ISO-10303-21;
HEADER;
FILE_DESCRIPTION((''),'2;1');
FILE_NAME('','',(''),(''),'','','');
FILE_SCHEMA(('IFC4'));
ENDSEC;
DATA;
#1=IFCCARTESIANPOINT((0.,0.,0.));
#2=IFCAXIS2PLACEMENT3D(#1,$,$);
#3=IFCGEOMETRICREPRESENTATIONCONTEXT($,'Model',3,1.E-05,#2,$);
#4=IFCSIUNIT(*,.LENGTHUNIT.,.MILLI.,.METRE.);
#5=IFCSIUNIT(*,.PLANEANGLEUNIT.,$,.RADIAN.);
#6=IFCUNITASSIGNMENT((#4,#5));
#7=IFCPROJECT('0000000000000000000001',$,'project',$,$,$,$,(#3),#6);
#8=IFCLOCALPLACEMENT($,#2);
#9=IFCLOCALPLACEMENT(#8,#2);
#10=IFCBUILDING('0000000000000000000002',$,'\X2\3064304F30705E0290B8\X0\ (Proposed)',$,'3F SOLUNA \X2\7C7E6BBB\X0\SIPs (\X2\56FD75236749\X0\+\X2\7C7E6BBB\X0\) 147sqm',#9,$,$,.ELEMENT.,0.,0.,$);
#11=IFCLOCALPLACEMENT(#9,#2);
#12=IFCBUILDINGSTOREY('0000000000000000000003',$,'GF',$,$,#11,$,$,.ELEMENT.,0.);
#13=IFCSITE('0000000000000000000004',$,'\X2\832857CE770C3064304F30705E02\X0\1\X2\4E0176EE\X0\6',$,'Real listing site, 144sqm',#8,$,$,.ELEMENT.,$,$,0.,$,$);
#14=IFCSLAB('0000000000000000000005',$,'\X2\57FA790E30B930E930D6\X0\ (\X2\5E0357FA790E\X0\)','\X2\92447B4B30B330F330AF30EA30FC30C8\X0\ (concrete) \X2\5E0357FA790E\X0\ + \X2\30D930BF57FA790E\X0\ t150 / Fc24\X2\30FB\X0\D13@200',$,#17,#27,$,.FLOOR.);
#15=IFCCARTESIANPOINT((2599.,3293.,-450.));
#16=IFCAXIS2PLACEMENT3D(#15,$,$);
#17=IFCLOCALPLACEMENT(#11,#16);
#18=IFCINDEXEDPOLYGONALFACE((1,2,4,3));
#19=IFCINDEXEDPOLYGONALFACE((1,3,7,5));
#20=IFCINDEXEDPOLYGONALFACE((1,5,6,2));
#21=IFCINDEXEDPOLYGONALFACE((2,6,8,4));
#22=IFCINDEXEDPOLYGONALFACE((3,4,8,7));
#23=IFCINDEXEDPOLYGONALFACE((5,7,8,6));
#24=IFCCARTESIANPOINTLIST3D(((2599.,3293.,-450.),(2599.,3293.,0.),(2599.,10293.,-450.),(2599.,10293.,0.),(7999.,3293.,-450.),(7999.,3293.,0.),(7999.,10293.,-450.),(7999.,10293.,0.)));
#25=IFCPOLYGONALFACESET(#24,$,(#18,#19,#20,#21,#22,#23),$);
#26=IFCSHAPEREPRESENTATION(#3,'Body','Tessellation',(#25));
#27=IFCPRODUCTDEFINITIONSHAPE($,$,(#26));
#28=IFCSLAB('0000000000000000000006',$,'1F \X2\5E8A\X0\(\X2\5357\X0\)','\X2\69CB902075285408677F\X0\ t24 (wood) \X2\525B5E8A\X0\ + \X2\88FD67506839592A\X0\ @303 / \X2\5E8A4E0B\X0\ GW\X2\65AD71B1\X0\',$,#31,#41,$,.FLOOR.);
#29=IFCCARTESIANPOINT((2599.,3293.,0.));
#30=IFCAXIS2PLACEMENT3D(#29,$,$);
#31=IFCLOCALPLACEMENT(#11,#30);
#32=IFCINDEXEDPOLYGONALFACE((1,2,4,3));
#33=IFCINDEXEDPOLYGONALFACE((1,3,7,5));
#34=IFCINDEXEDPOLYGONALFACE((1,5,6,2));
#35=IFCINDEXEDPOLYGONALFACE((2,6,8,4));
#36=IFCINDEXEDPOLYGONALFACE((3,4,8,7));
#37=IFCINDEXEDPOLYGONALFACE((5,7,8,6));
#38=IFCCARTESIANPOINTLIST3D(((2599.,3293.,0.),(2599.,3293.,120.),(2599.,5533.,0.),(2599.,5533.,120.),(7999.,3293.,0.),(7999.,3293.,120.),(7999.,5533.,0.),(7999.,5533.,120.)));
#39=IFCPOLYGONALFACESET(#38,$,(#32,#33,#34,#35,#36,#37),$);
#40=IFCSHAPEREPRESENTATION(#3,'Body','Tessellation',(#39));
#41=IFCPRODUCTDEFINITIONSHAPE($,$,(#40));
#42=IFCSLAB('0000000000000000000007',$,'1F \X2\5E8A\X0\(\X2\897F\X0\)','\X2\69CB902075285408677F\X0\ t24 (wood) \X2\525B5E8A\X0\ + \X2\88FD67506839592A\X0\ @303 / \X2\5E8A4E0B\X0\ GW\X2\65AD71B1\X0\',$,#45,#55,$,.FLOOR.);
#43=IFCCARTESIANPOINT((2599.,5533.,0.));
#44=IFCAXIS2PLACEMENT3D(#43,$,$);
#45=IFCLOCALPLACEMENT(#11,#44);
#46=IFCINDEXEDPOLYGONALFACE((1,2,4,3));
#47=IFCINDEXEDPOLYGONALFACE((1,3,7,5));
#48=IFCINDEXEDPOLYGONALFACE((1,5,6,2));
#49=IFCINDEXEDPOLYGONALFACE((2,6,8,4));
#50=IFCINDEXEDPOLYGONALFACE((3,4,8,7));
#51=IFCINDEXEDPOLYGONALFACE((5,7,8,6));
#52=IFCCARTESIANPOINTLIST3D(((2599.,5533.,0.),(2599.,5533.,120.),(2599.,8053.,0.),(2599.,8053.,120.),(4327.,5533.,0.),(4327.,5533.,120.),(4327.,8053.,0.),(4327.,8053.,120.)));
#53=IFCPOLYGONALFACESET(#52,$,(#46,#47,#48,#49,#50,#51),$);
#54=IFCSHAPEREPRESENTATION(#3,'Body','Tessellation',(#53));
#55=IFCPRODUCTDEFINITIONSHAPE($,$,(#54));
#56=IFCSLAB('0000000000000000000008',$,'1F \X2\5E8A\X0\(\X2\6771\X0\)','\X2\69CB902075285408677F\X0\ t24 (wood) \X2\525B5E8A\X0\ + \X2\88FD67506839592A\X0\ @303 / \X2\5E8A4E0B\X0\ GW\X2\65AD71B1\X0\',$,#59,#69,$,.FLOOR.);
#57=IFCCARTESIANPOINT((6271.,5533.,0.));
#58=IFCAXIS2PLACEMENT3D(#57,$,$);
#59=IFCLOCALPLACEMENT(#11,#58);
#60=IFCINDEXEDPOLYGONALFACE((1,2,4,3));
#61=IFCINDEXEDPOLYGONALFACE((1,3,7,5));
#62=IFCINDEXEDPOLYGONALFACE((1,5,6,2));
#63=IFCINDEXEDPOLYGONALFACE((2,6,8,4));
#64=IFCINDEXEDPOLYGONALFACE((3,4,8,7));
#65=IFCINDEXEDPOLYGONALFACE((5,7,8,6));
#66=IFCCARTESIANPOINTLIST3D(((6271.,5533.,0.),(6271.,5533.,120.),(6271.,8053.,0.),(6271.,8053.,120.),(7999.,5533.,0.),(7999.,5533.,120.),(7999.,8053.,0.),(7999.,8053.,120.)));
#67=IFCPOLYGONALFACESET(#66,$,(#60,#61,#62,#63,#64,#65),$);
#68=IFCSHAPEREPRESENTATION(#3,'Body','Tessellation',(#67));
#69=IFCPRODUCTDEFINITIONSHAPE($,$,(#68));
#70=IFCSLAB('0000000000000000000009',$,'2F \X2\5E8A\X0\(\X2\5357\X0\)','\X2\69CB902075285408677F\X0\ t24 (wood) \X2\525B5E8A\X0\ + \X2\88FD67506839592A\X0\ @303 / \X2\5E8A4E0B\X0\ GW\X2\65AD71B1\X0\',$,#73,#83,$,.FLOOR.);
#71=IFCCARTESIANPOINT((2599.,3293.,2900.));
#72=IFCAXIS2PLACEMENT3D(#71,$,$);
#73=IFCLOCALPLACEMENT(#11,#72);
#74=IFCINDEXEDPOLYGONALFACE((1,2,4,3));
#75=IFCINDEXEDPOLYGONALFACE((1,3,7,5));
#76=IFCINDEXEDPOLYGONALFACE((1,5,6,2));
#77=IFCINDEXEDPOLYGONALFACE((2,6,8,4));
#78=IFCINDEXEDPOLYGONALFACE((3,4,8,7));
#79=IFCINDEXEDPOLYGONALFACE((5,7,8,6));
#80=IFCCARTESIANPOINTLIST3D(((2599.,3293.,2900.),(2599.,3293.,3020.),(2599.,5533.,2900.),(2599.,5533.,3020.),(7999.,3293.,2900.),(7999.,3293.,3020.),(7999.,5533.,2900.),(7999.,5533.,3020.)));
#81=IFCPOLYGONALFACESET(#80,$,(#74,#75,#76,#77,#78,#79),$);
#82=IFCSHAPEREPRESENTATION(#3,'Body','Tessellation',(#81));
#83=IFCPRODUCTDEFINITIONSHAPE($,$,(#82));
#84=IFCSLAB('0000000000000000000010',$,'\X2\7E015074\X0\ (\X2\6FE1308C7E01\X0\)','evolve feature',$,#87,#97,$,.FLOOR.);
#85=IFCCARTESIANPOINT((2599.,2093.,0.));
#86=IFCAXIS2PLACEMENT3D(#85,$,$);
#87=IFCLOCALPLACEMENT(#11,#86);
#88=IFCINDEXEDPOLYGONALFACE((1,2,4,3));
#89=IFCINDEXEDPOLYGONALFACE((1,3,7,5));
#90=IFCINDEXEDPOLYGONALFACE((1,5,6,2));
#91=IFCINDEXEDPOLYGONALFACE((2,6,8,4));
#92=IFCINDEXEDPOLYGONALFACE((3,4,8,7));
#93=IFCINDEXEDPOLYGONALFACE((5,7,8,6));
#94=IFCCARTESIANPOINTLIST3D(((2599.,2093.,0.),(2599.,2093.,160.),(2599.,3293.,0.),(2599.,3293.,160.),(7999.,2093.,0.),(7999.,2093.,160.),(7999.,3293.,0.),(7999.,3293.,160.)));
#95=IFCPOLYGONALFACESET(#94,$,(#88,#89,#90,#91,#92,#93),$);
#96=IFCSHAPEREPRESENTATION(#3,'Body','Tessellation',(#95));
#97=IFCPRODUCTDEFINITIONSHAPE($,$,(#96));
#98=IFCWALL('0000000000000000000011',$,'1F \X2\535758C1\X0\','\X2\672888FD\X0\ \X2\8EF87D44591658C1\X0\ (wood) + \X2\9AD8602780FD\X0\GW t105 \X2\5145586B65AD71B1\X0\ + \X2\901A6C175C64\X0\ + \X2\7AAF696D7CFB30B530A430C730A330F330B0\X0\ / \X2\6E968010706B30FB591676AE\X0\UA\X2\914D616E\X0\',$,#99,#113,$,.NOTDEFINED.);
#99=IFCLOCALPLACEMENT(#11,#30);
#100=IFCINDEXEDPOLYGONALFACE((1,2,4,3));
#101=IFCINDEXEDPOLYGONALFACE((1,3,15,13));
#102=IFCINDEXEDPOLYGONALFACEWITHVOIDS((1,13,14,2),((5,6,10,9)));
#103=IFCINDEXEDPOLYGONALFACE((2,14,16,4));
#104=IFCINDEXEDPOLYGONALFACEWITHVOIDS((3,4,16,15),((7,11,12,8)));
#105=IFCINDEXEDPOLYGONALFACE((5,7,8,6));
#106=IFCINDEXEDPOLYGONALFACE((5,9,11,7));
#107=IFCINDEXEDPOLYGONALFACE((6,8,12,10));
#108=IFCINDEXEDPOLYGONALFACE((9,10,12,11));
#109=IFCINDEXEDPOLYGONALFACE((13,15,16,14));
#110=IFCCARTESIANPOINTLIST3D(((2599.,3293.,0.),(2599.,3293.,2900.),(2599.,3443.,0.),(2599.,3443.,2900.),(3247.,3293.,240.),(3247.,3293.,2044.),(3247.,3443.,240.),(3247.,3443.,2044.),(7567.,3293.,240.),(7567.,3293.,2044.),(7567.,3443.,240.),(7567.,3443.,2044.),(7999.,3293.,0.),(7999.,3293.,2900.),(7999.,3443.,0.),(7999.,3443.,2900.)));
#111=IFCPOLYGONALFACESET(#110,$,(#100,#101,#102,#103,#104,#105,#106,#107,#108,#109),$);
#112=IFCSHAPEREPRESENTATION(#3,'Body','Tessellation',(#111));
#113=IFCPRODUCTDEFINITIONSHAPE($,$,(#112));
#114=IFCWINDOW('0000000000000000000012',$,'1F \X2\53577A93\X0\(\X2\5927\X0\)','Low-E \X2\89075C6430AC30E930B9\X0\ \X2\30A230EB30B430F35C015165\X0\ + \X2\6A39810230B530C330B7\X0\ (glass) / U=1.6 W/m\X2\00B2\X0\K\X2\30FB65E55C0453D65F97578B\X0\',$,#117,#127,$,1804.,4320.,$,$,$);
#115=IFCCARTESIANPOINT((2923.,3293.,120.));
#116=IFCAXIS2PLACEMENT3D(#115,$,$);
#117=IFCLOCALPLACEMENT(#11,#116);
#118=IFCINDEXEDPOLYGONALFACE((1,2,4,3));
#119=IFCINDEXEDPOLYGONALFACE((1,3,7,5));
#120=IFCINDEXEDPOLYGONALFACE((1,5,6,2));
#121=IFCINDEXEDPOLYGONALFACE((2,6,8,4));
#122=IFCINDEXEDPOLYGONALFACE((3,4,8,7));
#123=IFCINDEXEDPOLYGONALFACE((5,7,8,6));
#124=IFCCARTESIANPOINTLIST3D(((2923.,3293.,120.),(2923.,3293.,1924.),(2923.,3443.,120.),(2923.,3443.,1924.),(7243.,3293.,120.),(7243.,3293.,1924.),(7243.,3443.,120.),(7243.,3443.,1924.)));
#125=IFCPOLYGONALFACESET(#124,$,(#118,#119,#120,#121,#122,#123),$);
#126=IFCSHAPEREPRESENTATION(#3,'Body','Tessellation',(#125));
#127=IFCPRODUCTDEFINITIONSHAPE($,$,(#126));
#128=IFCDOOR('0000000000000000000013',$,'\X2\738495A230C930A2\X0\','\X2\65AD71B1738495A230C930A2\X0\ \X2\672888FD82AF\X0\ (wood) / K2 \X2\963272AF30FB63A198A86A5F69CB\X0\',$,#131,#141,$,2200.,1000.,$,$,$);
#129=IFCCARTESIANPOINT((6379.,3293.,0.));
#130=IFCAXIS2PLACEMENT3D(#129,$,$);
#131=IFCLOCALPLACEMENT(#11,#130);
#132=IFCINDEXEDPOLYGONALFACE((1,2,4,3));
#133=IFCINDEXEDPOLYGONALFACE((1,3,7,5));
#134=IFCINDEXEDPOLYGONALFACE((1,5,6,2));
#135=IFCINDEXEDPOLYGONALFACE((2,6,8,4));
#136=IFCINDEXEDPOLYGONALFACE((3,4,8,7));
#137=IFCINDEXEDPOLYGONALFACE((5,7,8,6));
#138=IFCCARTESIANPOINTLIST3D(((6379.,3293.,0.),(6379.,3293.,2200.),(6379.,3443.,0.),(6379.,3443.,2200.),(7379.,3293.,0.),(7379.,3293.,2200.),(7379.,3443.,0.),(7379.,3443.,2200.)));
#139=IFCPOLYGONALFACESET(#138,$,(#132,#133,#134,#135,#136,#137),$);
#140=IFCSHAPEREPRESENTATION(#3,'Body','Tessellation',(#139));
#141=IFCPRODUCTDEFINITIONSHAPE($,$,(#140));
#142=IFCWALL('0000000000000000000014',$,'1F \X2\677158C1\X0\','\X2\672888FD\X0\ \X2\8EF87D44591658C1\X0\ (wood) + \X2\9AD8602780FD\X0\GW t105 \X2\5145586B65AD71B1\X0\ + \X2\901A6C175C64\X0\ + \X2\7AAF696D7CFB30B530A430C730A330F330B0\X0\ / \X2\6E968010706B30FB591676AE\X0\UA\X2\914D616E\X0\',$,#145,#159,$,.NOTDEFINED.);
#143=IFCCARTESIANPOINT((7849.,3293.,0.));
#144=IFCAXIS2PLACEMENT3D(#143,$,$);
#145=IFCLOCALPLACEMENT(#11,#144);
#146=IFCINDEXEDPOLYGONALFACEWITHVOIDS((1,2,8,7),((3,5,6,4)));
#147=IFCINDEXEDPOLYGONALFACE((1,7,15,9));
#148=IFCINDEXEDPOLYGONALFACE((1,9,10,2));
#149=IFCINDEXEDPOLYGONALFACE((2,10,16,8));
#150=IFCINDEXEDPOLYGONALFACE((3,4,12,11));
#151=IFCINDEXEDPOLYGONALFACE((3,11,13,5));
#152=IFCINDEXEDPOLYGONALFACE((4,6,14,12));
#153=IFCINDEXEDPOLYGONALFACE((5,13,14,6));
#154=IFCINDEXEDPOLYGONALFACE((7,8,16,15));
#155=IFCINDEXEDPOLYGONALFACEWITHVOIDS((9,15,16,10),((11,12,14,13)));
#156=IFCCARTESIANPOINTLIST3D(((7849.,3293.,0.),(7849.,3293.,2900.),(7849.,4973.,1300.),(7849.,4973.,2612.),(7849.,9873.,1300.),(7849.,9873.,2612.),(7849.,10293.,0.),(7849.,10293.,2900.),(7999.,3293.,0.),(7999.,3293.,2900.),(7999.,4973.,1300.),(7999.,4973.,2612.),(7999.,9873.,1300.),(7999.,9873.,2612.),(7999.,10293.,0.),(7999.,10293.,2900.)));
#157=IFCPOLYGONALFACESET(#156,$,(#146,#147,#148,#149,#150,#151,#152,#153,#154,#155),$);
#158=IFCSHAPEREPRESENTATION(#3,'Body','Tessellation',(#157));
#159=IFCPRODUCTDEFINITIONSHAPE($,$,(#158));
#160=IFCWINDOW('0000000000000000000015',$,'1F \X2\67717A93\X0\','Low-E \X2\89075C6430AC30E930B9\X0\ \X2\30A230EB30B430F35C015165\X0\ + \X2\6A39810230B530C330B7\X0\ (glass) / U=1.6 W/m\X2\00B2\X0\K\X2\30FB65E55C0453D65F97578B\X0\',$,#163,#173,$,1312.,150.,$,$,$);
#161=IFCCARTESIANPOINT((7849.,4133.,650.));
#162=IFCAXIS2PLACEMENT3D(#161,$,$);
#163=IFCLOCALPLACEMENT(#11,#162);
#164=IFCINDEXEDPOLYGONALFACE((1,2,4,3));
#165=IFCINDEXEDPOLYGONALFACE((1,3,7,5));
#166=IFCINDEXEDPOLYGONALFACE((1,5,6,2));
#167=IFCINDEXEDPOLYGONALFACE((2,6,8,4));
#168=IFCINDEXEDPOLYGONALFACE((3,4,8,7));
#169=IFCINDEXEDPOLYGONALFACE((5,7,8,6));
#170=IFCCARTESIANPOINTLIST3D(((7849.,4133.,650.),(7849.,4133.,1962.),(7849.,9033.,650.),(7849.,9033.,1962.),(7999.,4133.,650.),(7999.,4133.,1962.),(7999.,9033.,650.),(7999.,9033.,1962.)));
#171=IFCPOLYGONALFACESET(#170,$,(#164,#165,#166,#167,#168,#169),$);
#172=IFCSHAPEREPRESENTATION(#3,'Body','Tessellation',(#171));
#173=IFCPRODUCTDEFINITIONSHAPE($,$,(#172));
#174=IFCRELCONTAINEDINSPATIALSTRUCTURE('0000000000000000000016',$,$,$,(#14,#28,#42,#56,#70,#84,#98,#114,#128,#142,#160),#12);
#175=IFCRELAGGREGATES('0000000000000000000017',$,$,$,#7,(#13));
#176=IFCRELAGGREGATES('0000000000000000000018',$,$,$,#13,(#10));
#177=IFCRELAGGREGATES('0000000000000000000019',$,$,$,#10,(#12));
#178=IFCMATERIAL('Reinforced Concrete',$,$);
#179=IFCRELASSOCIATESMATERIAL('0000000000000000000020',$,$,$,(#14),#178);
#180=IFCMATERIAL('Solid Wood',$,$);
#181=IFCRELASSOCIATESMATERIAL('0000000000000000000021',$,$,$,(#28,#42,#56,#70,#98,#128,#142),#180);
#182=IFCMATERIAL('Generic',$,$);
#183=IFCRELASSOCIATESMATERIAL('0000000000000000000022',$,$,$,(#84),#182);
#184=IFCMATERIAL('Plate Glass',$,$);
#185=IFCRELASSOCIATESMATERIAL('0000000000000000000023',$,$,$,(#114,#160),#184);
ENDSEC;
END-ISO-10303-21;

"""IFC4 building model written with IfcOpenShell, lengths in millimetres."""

from ifc_helpers import new_model, si_unit, frame, frame_2d, origin, place, context, project, spatial, rectangle, extrude, material, element, fill, save


model = new_model("IFC4")

# Units and contexts
model_context = context("Model", 3, precision=1e-05, world=origin())
ifc_project = project(units=[si_unit("LENGTHUNIT", "METRE", prefix="MILLI"), si_unit("PLANEANGLEUNIT", "RADIAN")], contexts=[model_context])

# Site, building, storey
site_placement = place(None, origin())
site = spatial("IfcSite", under=ifc_project, at=site_placement, Name="茨城県つくば市1丁目6", ObjectType="Real listing site, 144sqm", CompositionType="ELEMENT", RefElevation=0.0)
building_placement = place(site_placement, origin())
building = spatial("IfcBuilding", under=site, at=building_placement, Name="つくば市邸 (Proposed)", ObjectType="3F SOLUNA 籾殻SIPs (国産杉+籾殻) 147sqm", CompositionType="ELEMENT", ElevationOfRefHeight=0.0, ElevationOfTerrain=0.0)
storey_placement = place(building_placement, origin())
storey = spatial("IfcBuildingStorey", under=building, at=storey_placement, Name="GF", CompositionType="ELEMENT", Elevation=0.0)

# Slabs
ifc_material_1 = material(Name="Reinforced Concrete")
slab_1_placement = place(storey_placement, frame((2599.0, 3293.0, -450.0)))
element("IfcSlab", 1, at=slab_1_placement, inside=storey, material=ifc_material_1, Name="基礎スラブ (布基礎)", Description="鉄筋コンクリート (concrete) 布基礎 + ベタ基礎 t150 / Fc24・D13@200", PredefinedType="FLOOR", context=model_context, shape_type="SweptSolid", body=[
    extrude(rectangle(XDim=5400.0, YDim=7000.0, at=frame_2d((2700.0, 3500.0))), frame((2599.0, 3293.0, -450.0)), (0.0, 0.0, 1.0), 450.0),
])
ifc_material_2 = material(Name="Solid Wood")
slab_2_placement = place(storey_placement, frame((2599.0, 3293.0, 0.0)))
element("IfcSlab", 2, at=slab_2_placement, inside=storey, material=ifc_material_2, Name="1F 床(南)", Description="構造用合板 t24 (wood) 剛床 + 製材根太 @303 / 床下 GW断熱", PredefinedType="FLOOR", context=model_context, shape_type="SweptSolid", body=[
    extrude(rectangle(XDim=5400.0, YDim=2240.0, at=frame_2d((2700.0, 1120.0))), frame((2599.0, 3293.0, 0.0)), (0.0, 0.0, 1.0), 120.0),
])
slab_3_placement = place(storey_placement, frame((2599.0, 5533.0, 0.0)))
element("IfcSlab", 3, at=slab_3_placement, inside=storey, material=ifc_material_2, Name="1F 床(西)", Description="構造用合板 t24 (wood) 剛床 + 製材根太 @303 / 床下 GW断熱", PredefinedType="FLOOR", context=model_context, shape_type="SweptSolid", body=[
    extrude(rectangle(XDim=1728.0, YDim=2520.0, at=frame_2d((864.0, 1260.0))), frame((2599.0, 5533.0, 0.0)), (0.0, 0.0, 1.0), 120.0),
])
slab_4_placement = place(storey_placement, frame((6271.0, 5533.0, 0.0)))
element("IfcSlab", 4, at=slab_4_placement, inside=storey, material=ifc_material_2, Name="1F 床(東)", Description="構造用合板 t24 (wood) 剛床 + 製材根太 @303 / 床下 GW断熱", PredefinedType="FLOOR", context=model_context, shape_type="SweptSolid", body=[
    extrude(rectangle(XDim=1728.0, YDim=2520.0, at=frame_2d((864.0, 1260.0))), frame((6271.0, 5533.0, 0.0)), (0.0, 0.0, 1.0), 120.0),
])
slab_5_placement = place(storey_placement, frame((2599.0, 3293.0, 2900.0)))
element("IfcSlab", 5, at=slab_5_placement, inside=storey, material=ifc_material_2, Name="2F 床(南)", Description="構造用合板 t24 (wood) 剛床 + 製材根太 @303 / 床下 GW断熱", PredefinedType="FLOOR", context=model_context, shape_type="SweptSolid", body=[
    extrude(rectangle(XDim=5400.0, YDim=2240.0, at=frame_2d((2700.0, 1120.0))), frame((2599.0, 3293.0, 2900.0)), (0.0, 0.0, 1.0), 120.0),
])
ifc_material_3 = material(Name="Generic")
slab_6_placement = place(storey_placement, frame((2599.0, 2093.0, 0.0)))
element("IfcSlab", 6, at=slab_6_placement, inside=storey, material=ifc_material_3, Name="縁側 (濡れ縁)", Description="evolve feature", PredefinedType="FLOOR", context=model_context, shape_type="SweptSolid", body=[
    extrude(rectangle(XDim=5400.0, YDim=1200.0, at=frame_2d((2700.0, 600.0))), frame((2599.0, 2093.0, 0.0)), (0.0, 0.0, 1.0), 160.0),
])

# Wall, openings, window, door
wall_1_placement = place(storey_placement, frame((2599.0, 3293.0, 0.0)))
wall_1 = element("IfcWall", 7, at=wall_1_placement, inside=storey, material=ifc_material_2, Name="1F 南壁", Description="木製 軸組外壁 (wood) + 高性能GW t105 充填断熱 + 通気層 + 窯業系サイディング / 準耐火・外皮UA配慮", PredefinedType="NOTDEFINED", context=model_context, shape_type="SweptSolid", body=[
    extrude(rectangle(XDim=5400.0, YDim=150.0, at=frame_2d((2700.0, 75.0))), frame((2599.0, 3293.0, 0.0)), (0.0, 0.0, 1.0), 2900.0),
])
opening_1_placement = place(storey_placement, frame((2923.0, 3293.0, 120.0)))
opening_1 = element("IfcOpeningElement", 8, at=opening_1_placement, cuts=wall_1, PredefinedType="NOTDEFINED", context=model_context, shape_type="SweptSolid", body=[
    extrude(rectangle(XDim=4320.0, YDim=150.0, at=frame_2d((2160.0, 75.0))), frame((2923.0, 3293.0, 120.0)), (0.0, 0.0, 1.0), 1804.0),
])
opening_2_placement = place(storey_placement, frame((6379.0, 3293.0, 0.0)))
opening_2 = element("IfcOpeningElement", 9, at=opening_2_placement, cuts=wall_1, PredefinedType="NOTDEFINED", context=model_context, shape_type="SweptSolid", body=[
    extrude(rectangle(XDim=1000.0, YDim=150.0, at=frame_2d((500.0, 75.0))), frame((6379.0, 3293.0, 0.0)), (0.0, 0.0, 1.0), 2200.0),
])
ifc_material_4 = material(Name="Plate Glass")
window_1_placement = place(storey_placement, frame((2923.0, 3293.0, 120.0)))
window_1 = element("IfcWindow", 10, at=window_1_placement, inside=storey, material=ifc_material_4, Name="1F 南窓(大)", Description="Low-E 複層ガラス アルゴン封入 + 樹脂サッシ (glass) / U=1.6 W/m²K・日射取得型", OverallHeight=1804.0, OverallWidth=4320.0, context=model_context, shape_type="SweptSolid", body=[
    extrude(rectangle(XDim=4320.0, YDim=150.0, at=frame_2d((2160.0, 75.0))), frame((2923.0, 3293.0, 120.0)), (0.0, 0.0, 1.0), 1804.0),
])
fill(opening_1, window_1)
door_placement = place(storey_placement, frame((6379.0, 3293.0, 0.0)))
door = element("IfcDoor", 11, at=door_placement, inside=storey, material=ifc_material_2, Name="玄関ドア", Description="断熱玄関ドア 木製芯 (wood) / K2 防犯・採風機構", OverallHeight=2200.0, OverallWidth=1000.0, context=model_context, shape_type="SweptSolid", body=[
    extrude(rectangle(XDim=1000.0, YDim=150.0, at=frame_2d((500.0, 75.0))), frame((6379.0, 3293.0, 0.0)), (0.0, 0.0, 1.0), 2200.0),
])
fill(opening_2, door)

# Wall, opening, window
wall_2_placement = place(storey_placement, frame((7849.0, 3293.0, 0.0)))
wall_2 = element("IfcWall", 12, at=wall_2_placement, inside=storey, material=ifc_material_2, Name="1F 東壁", Description="木製 軸組外壁 (wood) + 高性能GW t105 充填断熱 + 通気層 + 窯業系サイディング / 準耐火・外皮UA配慮", PredefinedType="NOTDEFINED", context=model_context, shape_type="SweptSolid", body=[
    extrude(rectangle(XDim=150.0, YDim=7000.0, at=frame_2d((75.0, 3500.0))), frame((7849.0, 3293.0, 0.0)), (0.0, 0.0, 1.0), 2900.0),
])
opening_3_placement = place(storey_placement, frame((7849.0, 4133.0, 650.0)))
opening_3 = element("IfcOpeningElement", 13, at=opening_3_placement, cuts=wall_2, PredefinedType="NOTDEFINED", context=model_context, shape_type="SweptSolid", body=[
    extrude(rectangle(XDim=150.0, YDim=4900.0, at=frame_2d((75.0, 2450.0))), frame((7849.0, 4133.0, 650.0)), (0.0, 0.0, 1.0), 1312.0),
])
window_2_placement = place(storey_placement, frame((7849.0, 4133.0, 650.0)))
window_2 = element("IfcWindow", 14, at=window_2_placement, inside=storey, material=ifc_material_4, Name="1F 東窓", Description="Low-E 複層ガラス アルゴン封入 + 樹脂サッシ (glass) / U=1.6 W/m²K・日射取得型", OverallHeight=1312.0, OverallWidth=150.0, context=model_context, shape_type="SweptSolid", body=[
    extrude(rectangle(XDim=150.0, YDim=4900.0, at=frame_2d((75.0, 2450.0))), frame((7849.0, 4133.0, 650.0)), (0.0, 0.0, 1.0), 1312.0),
])
fill(opening_3, window_2)

save(model, "model.ifc")
